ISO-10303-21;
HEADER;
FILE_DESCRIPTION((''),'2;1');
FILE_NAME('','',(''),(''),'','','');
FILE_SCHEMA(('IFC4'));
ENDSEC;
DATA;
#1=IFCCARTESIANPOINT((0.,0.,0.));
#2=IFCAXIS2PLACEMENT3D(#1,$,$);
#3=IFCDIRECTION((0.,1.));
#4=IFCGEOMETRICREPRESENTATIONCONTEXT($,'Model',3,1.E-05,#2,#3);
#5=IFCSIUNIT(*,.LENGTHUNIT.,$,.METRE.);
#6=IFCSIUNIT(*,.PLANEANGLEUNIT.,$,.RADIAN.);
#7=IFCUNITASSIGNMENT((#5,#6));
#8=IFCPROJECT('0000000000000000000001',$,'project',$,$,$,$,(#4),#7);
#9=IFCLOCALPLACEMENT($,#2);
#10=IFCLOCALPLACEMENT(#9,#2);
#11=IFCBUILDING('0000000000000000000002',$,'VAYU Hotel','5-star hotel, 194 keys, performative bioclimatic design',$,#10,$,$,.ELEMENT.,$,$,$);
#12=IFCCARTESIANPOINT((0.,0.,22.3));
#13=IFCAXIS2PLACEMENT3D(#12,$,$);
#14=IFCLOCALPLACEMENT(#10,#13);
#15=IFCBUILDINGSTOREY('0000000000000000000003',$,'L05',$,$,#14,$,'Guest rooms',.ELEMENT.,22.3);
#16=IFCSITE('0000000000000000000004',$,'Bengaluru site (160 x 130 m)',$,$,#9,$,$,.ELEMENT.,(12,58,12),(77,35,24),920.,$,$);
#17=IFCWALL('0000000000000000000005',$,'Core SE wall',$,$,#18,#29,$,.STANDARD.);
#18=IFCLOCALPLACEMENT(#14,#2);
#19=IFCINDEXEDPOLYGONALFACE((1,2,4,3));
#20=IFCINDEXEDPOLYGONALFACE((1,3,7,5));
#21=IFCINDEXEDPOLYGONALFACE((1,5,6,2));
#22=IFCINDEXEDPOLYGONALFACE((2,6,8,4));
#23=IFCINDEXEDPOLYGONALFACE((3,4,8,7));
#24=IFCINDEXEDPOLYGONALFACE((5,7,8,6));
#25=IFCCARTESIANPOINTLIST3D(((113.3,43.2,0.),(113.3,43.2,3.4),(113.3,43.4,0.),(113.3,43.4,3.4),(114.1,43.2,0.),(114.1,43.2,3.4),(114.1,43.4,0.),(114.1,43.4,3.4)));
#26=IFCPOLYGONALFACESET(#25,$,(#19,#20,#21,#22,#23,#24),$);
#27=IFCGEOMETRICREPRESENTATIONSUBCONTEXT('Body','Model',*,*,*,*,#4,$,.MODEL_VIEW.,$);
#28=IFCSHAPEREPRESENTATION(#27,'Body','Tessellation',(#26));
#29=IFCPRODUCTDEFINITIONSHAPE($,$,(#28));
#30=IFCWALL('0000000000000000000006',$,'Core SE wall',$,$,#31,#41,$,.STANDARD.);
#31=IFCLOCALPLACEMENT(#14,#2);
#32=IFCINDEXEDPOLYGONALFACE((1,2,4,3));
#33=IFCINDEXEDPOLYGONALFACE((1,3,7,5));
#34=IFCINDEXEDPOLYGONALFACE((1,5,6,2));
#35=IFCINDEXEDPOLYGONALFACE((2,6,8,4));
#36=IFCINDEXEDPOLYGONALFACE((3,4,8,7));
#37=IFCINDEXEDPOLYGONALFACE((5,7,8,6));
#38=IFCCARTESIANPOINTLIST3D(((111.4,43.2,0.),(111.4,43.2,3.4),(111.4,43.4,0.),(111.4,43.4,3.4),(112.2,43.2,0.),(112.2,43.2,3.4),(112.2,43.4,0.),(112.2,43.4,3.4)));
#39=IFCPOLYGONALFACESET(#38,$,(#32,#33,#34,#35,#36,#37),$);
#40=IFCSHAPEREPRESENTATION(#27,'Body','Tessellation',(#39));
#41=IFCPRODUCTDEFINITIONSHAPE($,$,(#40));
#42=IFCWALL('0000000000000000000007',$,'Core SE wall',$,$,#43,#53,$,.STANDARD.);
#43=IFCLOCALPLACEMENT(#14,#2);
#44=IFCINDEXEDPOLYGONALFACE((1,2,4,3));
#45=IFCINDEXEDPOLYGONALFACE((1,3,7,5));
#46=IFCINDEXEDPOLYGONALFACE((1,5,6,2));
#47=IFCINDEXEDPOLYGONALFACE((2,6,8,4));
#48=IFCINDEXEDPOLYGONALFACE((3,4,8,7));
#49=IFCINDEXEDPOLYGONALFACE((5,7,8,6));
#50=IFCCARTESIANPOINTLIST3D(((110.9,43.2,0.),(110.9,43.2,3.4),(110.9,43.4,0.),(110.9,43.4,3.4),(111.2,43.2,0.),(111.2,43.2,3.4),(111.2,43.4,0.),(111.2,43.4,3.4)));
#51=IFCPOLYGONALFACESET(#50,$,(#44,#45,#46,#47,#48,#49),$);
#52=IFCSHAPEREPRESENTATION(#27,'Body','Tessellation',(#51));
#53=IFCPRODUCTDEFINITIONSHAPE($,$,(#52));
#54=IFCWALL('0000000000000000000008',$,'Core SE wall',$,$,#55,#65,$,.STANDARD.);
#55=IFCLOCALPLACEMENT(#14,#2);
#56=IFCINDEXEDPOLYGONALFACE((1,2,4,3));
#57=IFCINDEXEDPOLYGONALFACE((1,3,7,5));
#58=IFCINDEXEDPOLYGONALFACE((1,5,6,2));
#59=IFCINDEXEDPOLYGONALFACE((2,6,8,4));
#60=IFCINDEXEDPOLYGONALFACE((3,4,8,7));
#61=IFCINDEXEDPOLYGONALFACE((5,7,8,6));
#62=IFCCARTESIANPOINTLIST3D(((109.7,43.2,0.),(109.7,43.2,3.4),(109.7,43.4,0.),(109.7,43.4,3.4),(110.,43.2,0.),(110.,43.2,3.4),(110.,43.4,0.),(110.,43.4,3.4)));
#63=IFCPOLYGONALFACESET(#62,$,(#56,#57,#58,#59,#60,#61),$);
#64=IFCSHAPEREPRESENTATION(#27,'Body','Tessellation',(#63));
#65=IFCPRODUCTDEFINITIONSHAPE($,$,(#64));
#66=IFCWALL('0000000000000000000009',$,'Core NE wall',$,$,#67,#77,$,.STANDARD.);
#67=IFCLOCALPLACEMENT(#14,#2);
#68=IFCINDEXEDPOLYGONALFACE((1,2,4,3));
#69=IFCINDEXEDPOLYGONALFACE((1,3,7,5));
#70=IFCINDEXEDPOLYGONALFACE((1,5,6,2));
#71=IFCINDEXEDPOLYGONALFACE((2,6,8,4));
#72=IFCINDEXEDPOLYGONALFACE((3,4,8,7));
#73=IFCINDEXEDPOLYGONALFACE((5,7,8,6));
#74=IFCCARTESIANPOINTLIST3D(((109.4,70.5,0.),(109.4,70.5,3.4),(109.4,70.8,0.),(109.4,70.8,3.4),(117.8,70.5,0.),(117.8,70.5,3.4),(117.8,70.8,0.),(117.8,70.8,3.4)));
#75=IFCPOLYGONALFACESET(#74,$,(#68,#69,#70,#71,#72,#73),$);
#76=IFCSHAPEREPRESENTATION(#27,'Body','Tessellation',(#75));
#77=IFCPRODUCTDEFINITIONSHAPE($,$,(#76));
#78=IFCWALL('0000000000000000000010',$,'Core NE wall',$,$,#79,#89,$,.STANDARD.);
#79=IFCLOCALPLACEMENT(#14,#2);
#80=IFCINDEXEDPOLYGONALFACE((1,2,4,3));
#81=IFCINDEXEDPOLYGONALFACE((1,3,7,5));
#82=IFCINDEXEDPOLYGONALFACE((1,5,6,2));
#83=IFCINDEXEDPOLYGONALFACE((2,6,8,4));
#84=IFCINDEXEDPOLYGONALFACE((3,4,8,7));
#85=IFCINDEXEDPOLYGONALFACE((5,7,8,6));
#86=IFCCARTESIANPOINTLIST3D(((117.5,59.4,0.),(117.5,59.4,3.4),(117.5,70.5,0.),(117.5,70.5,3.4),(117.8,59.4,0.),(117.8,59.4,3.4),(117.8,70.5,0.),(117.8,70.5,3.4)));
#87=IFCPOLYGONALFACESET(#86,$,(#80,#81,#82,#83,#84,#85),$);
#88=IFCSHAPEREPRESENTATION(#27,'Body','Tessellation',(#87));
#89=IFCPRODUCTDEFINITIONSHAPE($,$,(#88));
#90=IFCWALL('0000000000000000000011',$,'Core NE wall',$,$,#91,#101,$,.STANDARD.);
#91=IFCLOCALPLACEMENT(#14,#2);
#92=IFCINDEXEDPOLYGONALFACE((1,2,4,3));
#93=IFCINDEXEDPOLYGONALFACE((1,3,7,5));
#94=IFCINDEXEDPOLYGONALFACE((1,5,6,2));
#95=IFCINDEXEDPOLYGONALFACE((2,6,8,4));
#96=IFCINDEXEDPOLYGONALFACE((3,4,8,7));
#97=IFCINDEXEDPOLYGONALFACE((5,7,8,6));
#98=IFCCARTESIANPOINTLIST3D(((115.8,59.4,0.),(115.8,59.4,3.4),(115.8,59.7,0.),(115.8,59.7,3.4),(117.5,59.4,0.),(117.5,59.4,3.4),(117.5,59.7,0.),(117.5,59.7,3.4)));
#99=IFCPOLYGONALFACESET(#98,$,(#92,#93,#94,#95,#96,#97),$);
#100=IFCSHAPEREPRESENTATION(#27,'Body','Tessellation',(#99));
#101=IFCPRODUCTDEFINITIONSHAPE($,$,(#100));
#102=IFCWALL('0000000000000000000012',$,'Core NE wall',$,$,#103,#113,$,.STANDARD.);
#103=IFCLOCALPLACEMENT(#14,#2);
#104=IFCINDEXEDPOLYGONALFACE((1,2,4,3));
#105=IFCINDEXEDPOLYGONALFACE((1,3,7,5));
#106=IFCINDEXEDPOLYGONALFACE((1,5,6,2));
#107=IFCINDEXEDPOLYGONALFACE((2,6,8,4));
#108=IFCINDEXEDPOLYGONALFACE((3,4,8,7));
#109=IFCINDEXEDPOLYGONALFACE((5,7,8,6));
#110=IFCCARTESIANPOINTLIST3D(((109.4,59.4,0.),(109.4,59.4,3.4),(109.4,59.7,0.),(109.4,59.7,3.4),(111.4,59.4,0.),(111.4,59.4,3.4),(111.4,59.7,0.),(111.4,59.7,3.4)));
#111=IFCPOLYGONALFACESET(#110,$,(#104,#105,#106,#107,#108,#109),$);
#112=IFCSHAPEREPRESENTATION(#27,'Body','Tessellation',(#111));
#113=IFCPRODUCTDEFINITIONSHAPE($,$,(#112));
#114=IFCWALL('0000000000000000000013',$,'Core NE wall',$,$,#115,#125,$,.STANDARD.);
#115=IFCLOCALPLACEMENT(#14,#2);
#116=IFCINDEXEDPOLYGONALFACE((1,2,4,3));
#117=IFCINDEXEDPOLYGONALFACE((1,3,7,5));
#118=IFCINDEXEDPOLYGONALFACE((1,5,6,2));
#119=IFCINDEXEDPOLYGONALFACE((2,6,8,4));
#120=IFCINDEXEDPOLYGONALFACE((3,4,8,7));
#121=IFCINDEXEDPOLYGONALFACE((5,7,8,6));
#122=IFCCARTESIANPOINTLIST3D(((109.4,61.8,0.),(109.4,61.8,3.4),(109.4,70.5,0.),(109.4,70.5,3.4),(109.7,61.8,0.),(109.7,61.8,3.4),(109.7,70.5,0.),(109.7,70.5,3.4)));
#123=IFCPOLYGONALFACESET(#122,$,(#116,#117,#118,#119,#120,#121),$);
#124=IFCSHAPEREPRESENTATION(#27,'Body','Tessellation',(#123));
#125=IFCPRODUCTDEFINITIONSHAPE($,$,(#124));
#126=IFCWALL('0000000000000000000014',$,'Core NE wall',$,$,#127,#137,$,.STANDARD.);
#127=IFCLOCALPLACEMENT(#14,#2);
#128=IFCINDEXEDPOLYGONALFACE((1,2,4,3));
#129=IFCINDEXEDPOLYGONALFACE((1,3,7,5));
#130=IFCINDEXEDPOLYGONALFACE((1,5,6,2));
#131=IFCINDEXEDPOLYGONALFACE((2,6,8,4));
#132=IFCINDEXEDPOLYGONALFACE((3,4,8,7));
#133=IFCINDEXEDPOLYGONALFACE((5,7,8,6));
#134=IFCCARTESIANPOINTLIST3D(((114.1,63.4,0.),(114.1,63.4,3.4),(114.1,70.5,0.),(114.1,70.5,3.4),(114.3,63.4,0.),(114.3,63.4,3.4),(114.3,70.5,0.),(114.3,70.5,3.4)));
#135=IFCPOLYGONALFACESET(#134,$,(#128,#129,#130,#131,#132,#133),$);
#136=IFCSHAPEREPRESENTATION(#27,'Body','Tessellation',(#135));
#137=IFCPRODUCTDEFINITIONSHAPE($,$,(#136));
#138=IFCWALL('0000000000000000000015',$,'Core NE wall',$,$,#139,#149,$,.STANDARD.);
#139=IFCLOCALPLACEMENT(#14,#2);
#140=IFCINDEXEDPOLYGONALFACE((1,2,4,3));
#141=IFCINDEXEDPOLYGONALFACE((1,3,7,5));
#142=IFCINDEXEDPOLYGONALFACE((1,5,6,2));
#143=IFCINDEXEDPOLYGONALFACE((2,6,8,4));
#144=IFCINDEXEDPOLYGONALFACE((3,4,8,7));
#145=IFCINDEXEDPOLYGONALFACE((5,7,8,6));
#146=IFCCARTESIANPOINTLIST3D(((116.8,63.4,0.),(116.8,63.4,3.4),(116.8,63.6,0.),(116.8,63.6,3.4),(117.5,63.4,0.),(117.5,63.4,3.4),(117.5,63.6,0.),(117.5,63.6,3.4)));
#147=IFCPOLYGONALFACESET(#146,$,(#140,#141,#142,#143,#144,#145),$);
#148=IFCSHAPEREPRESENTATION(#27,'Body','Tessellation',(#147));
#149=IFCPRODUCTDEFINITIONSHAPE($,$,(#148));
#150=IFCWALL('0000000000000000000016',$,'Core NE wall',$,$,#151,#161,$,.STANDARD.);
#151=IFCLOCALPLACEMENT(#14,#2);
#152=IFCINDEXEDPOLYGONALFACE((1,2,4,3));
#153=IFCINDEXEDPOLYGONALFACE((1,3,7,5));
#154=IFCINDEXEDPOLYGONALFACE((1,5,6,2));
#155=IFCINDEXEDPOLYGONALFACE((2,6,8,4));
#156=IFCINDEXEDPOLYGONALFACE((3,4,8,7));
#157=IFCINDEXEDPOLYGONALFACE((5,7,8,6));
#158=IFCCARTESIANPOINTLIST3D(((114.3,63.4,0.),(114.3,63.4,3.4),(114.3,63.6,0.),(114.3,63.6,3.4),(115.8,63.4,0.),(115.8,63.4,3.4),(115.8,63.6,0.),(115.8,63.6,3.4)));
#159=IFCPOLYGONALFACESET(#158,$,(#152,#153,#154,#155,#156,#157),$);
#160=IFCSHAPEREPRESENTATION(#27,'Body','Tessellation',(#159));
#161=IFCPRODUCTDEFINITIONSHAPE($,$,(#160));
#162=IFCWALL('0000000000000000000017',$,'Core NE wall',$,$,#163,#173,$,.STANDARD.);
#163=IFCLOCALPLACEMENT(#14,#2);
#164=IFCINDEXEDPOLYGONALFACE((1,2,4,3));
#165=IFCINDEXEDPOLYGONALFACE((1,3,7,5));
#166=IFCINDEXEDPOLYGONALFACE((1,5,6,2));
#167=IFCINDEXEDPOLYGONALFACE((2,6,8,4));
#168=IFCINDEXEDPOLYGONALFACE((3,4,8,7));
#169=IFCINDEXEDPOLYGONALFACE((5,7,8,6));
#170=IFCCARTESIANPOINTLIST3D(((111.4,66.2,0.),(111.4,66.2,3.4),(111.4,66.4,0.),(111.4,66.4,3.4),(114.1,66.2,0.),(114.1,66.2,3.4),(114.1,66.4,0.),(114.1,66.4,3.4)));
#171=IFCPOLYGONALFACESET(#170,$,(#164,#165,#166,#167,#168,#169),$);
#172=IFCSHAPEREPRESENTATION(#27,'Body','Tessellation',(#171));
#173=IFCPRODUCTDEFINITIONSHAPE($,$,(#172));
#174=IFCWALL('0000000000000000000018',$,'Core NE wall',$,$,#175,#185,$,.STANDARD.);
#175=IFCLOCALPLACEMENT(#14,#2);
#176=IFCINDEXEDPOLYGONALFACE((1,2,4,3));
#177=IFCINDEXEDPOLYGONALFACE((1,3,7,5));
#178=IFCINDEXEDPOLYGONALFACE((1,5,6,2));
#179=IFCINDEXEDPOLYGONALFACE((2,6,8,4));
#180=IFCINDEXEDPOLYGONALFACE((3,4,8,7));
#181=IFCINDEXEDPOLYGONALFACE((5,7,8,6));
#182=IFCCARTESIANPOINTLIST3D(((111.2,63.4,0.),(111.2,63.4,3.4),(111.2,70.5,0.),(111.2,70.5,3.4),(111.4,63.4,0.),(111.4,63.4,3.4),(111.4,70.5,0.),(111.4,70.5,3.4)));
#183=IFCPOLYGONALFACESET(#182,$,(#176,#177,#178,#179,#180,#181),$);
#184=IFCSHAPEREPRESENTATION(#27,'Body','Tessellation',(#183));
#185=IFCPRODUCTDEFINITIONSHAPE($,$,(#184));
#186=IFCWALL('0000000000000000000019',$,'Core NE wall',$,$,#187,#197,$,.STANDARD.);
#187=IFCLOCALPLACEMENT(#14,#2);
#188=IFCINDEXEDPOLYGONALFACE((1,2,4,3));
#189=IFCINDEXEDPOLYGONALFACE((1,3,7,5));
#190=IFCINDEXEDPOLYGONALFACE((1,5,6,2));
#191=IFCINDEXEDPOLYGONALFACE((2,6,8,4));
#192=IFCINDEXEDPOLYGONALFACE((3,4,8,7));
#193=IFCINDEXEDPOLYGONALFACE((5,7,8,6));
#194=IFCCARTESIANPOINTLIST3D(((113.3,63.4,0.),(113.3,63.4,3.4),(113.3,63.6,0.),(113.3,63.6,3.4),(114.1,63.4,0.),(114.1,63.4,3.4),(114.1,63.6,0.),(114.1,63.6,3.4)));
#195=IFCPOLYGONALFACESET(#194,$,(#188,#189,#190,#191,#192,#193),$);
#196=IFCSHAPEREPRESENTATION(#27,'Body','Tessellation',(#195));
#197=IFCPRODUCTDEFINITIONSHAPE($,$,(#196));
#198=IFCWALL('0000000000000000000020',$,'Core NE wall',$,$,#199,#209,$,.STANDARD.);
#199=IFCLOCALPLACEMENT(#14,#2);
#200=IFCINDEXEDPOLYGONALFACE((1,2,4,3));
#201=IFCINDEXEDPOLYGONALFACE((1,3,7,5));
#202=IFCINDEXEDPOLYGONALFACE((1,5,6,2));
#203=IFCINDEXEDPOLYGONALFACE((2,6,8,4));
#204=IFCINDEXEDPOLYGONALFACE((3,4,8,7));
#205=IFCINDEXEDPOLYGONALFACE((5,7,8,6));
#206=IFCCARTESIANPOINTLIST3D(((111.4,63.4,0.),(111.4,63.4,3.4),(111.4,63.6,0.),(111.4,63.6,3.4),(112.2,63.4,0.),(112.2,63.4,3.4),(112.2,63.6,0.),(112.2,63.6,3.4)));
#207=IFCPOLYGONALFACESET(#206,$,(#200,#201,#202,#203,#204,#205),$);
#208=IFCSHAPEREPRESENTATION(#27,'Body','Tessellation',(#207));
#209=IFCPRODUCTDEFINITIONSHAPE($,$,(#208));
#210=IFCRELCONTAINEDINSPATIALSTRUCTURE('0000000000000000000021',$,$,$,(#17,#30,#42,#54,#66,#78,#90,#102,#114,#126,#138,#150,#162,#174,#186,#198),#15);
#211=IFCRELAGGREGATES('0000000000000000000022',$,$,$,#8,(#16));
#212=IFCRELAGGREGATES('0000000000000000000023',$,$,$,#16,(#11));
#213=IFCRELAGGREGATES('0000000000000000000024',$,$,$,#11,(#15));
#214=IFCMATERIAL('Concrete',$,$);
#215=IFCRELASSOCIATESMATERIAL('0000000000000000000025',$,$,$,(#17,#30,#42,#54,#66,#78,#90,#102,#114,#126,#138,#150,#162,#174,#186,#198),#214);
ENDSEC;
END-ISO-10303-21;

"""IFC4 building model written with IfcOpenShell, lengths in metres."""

from ifc_helpers import new_model, si_unit, direction, frame, origin, place, context, subcontext, project, spatial, polyline, outline, extrude, material, element, save


model = new_model("IFC4")

# Units and contexts
model_context = context("Model", 3, precision=1e-05, world=origin(), true_north=direction((0.0, 1.0)))
body_context = subcontext(model_context, "Body", "Model", "MODEL_VIEW")
ifc_project = project(units=[si_unit("LENGTHUNIT", "METRE"), si_unit("PLANEANGLEUNIT", "RADIAN")], contexts=[model_context])

# Site, building, storey
site_placement = place(None, origin())
site = spatial("IfcSite", under=ifc_project, at=site_placement, Name="Bengaluru site (160 x 130 m)", CompositionType="ELEMENT", RefLatitude=(12, 58, 12), RefLongitude=(77, 35, 24), RefElevation=920.0)
building_placement = place(site_placement, origin())
building = spatial("IfcBuilding", under=site, at=building_placement, Name="VAYU Hotel", Description="5-star hotel, 194 keys, performative bioclimatic design", CompositionType="ELEMENT")
storey_placement = place(building_placement, frame((0.0, 0.0, 22.3)))
storey = spatial("IfcBuildingStorey", under=building, at=storey_placement, Name="L05", LongName="Guest rooms", CompositionType="ELEMENT", Elevation=22.3)

# Shared definitions
ifc_material_1 = material(Name="Concrete")

# Walls
wall_1_placement = place(storey_placement, origin())
element("IfcWall", 1, at=wall_1_placement, inside=storey, material=ifc_material_1, Name="Core SE wall", PredefinedType="STANDARD", context=body_context, shape_type="SweptSolid", body=[
    extrude(outline(polyline([(113.3, 43.4), (114.1, 43.4), (114.1, 43.2), (113.3, 43.2), (113.3, 43.4)])), origin(), (0.0, 0.0, 1.0), 3.4),
])
wall_2_placement = place(storey_placement, origin())
element("IfcWall", 2, at=wall_2_placement, inside=storey, material=ifc_material_1, Name="Core SE wall", PredefinedType="STANDARD", context=body_context, shape_type="SweptSolid", body=[
    extrude(outline(polyline([(111.4, 43.4), (112.2, 43.4), (112.2, 43.2), (111.4, 43.2), (111.4, 43.4)])), origin(), (0.0, 0.0, 1.0), 3.4),
])
wall_3_placement = place(storey_placement, origin())
element("IfcWall", 3, at=wall_3_placement, inside=storey, material=ifc_material_1, Name="Core SE wall", PredefinedType="STANDARD", context=body_context, shape_type="SweptSolid", body=[
    extrude(outline(polyline([(110.9, 43.4), (111.2, 43.4), (111.2, 43.2), (110.9, 43.2), (110.9, 43.4)])), origin(), (0.0, 0.0, 1.0), 3.4),
])
wall_4_placement = place(storey_placement, origin())
element("IfcWall", 4, at=wall_4_placement, inside=storey, material=ifc_material_1, Name="Core SE wall", PredefinedType="STANDARD", context=body_context, shape_type="SweptSolid", body=[
    extrude(outline(polyline([(109.7, 43.4), (110.0, 43.4), (110.0, 43.2), (109.7, 43.2), (109.7, 43.4)])), origin(), (0.0, 0.0, 1.0), 3.4),
])
wall_5_placement = place(storey_placement, origin())
element("IfcWall", 5, at=wall_5_placement, inside=storey, material=ifc_material_1, Name="Core NE wall", PredefinedType="STANDARD", context=body_context, shape_type="SweptSolid", body=[
    extrude(outline(polyline([(109.4, 70.8), (117.8, 70.8), (117.8, 70.5), (109.4, 70.5), (109.4, 70.8)])), origin(), (0.0, 0.0, 1.0), 3.4),
])
wall_6_placement = place(storey_placement, origin())
element("IfcWall", 6, at=wall_6_placement, inside=storey, material=ifc_material_1, Name="Core NE wall", PredefinedType="STANDARD", context=body_context, shape_type="SweptSolid", body=[
    extrude(outline(polyline([(117.5, 59.4), (117.5, 70.5), (117.8, 70.5), (117.8, 59.4), (117.5, 59.4)])), origin(), (0.0, 0.0, 1.0), 3.4),
])
wall_7_placement = place(storey_placement, origin())
element("IfcWall", 7, at=wall_7_placement, inside=storey, material=ifc_material_1, Name="Core NE wall", PredefinedType="STANDARD", context=body_context, shape_type="SweptSolid", body=[
    extrude(outline(polyline([(115.8, 59.7), (117.5, 59.7), (117.5, 59.4), (115.8, 59.4), (115.8, 59.7)])), origin(), (0.0, 0.0, 1.0), 3.4),
])
wall_8_placement = place(storey_placement, origin())
element("IfcWall", 8, at=wall_8_placement, inside=storey, material=ifc_material_1, Name="Core NE wall", PredefinedType="STANDARD", context=body_context, shape_type="SweptSolid", body=[
    extrude(outline(polyline([(109.4, 59.7), (111.4, 59.7), (111.4, 59.4), (109.4, 59.4), (109.4, 59.7)])), origin(), (0.0, 0.0, 1.0), 3.4),
])
wall_9_placement = place(storey_placement, origin())
element("IfcWall", 9, at=wall_9_placement, inside=storey, material=ifc_material_1, Name="Core NE wall", PredefinedType="STANDARD", context=body_context, shape_type="SweptSolid", body=[
    extrude(outline(polyline([(109.4, 61.8), (109.4, 70.5), (109.7, 70.5), (109.7, 61.8), (109.4, 61.8)])), origin(), (0.0, 0.0, 1.0), 3.4),
])
wall_10_placement = place(storey_placement, origin())
element("IfcWall", 10, at=wall_10_placement, inside=storey, material=ifc_material_1, Name="Core NE wall", PredefinedType="STANDARD", context=body_context, shape_type="SweptSolid", body=[
    extrude(outline(polyline([(114.1, 63.4), (114.1, 70.5), (114.3, 70.5), (114.3, 63.4), (114.1, 63.4)])), origin(), (0.0, 0.0, 1.0), 3.4),
])
wall_11_placement = place(storey_placement, origin())
element("IfcWall", 11, at=wall_11_placement, inside=storey, material=ifc_material_1, Name="Core NE wall", PredefinedType="STANDARD", context=body_context, shape_type="SweptSolid", body=[
    extrude(outline(polyline([(116.8, 63.6), (117.5, 63.6), (117.5, 63.4), (116.8, 63.4), (116.8, 63.6)])), origin(), (0.0, 0.0, 1.0), 3.4),
])
wall_12_placement = place(storey_placement, origin())
element("IfcWall", 12, at=wall_12_placement, inside=storey, material=ifc_material_1, Name="Core NE wall", PredefinedType="STANDARD", context=body_context, shape_type="SweptSolid", body=[
    extrude(outline(polyline([(114.3, 63.6), (115.8, 63.6), (115.8, 63.4), (114.3, 63.4), (114.3, 63.6)])), origin(), (0.0, 0.0, 1.0), 3.4),
])
wall_13_placement = place(storey_placement, origin())
element("IfcWall", 13, at=wall_13_placement, inside=storey, material=ifc_material_1, Name="Core NE wall", PredefinedType="STANDARD", context=body_context, shape_type="SweptSolid", body=[
    extrude(outline(polyline([(111.4, 66.4), (114.1, 66.4), (114.1, 66.2), (111.4, 66.2), (111.4, 66.4)])), origin(), (0.0, 0.0, 1.0), 3.4),
])
wall_14_placement = place(storey_placement, origin())
element("IfcWall", 14, at=wall_14_placement, inside=storey, material=ifc_material_1, Name="Core NE wall", PredefinedType="STANDARD", context=body_context, shape_type="SweptSolid", body=[
    extrude(outline(polyline([(111.2, 63.4), (111.2, 70.5), (111.4, 70.5), (111.4, 63.4), (111.2, 63.4)])), origin(), (0.0, 0.0, 1.0), 3.4),
])
wall_15_placement = place(storey_placement, origin())
element("IfcWall", 15, at=wall_15_placement, inside=storey, material=ifc_material_1, Name="Core NE wall", PredefinedType="STANDARD", context=body_context, shape_type="SweptSolid", body=[
    extrude(outline(polyline([(113.3, 63.6), (114.1, 63.6), (114.1, 63.4), (113.3, 63.4), (113.3, 63.6)])), origin(), (0.0, 0.0, 1.0), 3.4),
])
wall_16_placement = place(storey_placement, origin())
element("IfcWall", 16, at=wall_16_placement, inside=storey, material=ifc_material_1, Name="Core NE wall", PredefinedType="STANDARD", context=body_context, shape_type="SweptSolid", body=[
    extrude(outline(polyline([(111.4, 63.6), (112.2, 63.6), (112.2, 63.4), (111.4, 63.4), (111.4, 63.6)])), origin(), (0.0, 0.0, 1.0), 3.4),
])

save(model, "model.ifc")
